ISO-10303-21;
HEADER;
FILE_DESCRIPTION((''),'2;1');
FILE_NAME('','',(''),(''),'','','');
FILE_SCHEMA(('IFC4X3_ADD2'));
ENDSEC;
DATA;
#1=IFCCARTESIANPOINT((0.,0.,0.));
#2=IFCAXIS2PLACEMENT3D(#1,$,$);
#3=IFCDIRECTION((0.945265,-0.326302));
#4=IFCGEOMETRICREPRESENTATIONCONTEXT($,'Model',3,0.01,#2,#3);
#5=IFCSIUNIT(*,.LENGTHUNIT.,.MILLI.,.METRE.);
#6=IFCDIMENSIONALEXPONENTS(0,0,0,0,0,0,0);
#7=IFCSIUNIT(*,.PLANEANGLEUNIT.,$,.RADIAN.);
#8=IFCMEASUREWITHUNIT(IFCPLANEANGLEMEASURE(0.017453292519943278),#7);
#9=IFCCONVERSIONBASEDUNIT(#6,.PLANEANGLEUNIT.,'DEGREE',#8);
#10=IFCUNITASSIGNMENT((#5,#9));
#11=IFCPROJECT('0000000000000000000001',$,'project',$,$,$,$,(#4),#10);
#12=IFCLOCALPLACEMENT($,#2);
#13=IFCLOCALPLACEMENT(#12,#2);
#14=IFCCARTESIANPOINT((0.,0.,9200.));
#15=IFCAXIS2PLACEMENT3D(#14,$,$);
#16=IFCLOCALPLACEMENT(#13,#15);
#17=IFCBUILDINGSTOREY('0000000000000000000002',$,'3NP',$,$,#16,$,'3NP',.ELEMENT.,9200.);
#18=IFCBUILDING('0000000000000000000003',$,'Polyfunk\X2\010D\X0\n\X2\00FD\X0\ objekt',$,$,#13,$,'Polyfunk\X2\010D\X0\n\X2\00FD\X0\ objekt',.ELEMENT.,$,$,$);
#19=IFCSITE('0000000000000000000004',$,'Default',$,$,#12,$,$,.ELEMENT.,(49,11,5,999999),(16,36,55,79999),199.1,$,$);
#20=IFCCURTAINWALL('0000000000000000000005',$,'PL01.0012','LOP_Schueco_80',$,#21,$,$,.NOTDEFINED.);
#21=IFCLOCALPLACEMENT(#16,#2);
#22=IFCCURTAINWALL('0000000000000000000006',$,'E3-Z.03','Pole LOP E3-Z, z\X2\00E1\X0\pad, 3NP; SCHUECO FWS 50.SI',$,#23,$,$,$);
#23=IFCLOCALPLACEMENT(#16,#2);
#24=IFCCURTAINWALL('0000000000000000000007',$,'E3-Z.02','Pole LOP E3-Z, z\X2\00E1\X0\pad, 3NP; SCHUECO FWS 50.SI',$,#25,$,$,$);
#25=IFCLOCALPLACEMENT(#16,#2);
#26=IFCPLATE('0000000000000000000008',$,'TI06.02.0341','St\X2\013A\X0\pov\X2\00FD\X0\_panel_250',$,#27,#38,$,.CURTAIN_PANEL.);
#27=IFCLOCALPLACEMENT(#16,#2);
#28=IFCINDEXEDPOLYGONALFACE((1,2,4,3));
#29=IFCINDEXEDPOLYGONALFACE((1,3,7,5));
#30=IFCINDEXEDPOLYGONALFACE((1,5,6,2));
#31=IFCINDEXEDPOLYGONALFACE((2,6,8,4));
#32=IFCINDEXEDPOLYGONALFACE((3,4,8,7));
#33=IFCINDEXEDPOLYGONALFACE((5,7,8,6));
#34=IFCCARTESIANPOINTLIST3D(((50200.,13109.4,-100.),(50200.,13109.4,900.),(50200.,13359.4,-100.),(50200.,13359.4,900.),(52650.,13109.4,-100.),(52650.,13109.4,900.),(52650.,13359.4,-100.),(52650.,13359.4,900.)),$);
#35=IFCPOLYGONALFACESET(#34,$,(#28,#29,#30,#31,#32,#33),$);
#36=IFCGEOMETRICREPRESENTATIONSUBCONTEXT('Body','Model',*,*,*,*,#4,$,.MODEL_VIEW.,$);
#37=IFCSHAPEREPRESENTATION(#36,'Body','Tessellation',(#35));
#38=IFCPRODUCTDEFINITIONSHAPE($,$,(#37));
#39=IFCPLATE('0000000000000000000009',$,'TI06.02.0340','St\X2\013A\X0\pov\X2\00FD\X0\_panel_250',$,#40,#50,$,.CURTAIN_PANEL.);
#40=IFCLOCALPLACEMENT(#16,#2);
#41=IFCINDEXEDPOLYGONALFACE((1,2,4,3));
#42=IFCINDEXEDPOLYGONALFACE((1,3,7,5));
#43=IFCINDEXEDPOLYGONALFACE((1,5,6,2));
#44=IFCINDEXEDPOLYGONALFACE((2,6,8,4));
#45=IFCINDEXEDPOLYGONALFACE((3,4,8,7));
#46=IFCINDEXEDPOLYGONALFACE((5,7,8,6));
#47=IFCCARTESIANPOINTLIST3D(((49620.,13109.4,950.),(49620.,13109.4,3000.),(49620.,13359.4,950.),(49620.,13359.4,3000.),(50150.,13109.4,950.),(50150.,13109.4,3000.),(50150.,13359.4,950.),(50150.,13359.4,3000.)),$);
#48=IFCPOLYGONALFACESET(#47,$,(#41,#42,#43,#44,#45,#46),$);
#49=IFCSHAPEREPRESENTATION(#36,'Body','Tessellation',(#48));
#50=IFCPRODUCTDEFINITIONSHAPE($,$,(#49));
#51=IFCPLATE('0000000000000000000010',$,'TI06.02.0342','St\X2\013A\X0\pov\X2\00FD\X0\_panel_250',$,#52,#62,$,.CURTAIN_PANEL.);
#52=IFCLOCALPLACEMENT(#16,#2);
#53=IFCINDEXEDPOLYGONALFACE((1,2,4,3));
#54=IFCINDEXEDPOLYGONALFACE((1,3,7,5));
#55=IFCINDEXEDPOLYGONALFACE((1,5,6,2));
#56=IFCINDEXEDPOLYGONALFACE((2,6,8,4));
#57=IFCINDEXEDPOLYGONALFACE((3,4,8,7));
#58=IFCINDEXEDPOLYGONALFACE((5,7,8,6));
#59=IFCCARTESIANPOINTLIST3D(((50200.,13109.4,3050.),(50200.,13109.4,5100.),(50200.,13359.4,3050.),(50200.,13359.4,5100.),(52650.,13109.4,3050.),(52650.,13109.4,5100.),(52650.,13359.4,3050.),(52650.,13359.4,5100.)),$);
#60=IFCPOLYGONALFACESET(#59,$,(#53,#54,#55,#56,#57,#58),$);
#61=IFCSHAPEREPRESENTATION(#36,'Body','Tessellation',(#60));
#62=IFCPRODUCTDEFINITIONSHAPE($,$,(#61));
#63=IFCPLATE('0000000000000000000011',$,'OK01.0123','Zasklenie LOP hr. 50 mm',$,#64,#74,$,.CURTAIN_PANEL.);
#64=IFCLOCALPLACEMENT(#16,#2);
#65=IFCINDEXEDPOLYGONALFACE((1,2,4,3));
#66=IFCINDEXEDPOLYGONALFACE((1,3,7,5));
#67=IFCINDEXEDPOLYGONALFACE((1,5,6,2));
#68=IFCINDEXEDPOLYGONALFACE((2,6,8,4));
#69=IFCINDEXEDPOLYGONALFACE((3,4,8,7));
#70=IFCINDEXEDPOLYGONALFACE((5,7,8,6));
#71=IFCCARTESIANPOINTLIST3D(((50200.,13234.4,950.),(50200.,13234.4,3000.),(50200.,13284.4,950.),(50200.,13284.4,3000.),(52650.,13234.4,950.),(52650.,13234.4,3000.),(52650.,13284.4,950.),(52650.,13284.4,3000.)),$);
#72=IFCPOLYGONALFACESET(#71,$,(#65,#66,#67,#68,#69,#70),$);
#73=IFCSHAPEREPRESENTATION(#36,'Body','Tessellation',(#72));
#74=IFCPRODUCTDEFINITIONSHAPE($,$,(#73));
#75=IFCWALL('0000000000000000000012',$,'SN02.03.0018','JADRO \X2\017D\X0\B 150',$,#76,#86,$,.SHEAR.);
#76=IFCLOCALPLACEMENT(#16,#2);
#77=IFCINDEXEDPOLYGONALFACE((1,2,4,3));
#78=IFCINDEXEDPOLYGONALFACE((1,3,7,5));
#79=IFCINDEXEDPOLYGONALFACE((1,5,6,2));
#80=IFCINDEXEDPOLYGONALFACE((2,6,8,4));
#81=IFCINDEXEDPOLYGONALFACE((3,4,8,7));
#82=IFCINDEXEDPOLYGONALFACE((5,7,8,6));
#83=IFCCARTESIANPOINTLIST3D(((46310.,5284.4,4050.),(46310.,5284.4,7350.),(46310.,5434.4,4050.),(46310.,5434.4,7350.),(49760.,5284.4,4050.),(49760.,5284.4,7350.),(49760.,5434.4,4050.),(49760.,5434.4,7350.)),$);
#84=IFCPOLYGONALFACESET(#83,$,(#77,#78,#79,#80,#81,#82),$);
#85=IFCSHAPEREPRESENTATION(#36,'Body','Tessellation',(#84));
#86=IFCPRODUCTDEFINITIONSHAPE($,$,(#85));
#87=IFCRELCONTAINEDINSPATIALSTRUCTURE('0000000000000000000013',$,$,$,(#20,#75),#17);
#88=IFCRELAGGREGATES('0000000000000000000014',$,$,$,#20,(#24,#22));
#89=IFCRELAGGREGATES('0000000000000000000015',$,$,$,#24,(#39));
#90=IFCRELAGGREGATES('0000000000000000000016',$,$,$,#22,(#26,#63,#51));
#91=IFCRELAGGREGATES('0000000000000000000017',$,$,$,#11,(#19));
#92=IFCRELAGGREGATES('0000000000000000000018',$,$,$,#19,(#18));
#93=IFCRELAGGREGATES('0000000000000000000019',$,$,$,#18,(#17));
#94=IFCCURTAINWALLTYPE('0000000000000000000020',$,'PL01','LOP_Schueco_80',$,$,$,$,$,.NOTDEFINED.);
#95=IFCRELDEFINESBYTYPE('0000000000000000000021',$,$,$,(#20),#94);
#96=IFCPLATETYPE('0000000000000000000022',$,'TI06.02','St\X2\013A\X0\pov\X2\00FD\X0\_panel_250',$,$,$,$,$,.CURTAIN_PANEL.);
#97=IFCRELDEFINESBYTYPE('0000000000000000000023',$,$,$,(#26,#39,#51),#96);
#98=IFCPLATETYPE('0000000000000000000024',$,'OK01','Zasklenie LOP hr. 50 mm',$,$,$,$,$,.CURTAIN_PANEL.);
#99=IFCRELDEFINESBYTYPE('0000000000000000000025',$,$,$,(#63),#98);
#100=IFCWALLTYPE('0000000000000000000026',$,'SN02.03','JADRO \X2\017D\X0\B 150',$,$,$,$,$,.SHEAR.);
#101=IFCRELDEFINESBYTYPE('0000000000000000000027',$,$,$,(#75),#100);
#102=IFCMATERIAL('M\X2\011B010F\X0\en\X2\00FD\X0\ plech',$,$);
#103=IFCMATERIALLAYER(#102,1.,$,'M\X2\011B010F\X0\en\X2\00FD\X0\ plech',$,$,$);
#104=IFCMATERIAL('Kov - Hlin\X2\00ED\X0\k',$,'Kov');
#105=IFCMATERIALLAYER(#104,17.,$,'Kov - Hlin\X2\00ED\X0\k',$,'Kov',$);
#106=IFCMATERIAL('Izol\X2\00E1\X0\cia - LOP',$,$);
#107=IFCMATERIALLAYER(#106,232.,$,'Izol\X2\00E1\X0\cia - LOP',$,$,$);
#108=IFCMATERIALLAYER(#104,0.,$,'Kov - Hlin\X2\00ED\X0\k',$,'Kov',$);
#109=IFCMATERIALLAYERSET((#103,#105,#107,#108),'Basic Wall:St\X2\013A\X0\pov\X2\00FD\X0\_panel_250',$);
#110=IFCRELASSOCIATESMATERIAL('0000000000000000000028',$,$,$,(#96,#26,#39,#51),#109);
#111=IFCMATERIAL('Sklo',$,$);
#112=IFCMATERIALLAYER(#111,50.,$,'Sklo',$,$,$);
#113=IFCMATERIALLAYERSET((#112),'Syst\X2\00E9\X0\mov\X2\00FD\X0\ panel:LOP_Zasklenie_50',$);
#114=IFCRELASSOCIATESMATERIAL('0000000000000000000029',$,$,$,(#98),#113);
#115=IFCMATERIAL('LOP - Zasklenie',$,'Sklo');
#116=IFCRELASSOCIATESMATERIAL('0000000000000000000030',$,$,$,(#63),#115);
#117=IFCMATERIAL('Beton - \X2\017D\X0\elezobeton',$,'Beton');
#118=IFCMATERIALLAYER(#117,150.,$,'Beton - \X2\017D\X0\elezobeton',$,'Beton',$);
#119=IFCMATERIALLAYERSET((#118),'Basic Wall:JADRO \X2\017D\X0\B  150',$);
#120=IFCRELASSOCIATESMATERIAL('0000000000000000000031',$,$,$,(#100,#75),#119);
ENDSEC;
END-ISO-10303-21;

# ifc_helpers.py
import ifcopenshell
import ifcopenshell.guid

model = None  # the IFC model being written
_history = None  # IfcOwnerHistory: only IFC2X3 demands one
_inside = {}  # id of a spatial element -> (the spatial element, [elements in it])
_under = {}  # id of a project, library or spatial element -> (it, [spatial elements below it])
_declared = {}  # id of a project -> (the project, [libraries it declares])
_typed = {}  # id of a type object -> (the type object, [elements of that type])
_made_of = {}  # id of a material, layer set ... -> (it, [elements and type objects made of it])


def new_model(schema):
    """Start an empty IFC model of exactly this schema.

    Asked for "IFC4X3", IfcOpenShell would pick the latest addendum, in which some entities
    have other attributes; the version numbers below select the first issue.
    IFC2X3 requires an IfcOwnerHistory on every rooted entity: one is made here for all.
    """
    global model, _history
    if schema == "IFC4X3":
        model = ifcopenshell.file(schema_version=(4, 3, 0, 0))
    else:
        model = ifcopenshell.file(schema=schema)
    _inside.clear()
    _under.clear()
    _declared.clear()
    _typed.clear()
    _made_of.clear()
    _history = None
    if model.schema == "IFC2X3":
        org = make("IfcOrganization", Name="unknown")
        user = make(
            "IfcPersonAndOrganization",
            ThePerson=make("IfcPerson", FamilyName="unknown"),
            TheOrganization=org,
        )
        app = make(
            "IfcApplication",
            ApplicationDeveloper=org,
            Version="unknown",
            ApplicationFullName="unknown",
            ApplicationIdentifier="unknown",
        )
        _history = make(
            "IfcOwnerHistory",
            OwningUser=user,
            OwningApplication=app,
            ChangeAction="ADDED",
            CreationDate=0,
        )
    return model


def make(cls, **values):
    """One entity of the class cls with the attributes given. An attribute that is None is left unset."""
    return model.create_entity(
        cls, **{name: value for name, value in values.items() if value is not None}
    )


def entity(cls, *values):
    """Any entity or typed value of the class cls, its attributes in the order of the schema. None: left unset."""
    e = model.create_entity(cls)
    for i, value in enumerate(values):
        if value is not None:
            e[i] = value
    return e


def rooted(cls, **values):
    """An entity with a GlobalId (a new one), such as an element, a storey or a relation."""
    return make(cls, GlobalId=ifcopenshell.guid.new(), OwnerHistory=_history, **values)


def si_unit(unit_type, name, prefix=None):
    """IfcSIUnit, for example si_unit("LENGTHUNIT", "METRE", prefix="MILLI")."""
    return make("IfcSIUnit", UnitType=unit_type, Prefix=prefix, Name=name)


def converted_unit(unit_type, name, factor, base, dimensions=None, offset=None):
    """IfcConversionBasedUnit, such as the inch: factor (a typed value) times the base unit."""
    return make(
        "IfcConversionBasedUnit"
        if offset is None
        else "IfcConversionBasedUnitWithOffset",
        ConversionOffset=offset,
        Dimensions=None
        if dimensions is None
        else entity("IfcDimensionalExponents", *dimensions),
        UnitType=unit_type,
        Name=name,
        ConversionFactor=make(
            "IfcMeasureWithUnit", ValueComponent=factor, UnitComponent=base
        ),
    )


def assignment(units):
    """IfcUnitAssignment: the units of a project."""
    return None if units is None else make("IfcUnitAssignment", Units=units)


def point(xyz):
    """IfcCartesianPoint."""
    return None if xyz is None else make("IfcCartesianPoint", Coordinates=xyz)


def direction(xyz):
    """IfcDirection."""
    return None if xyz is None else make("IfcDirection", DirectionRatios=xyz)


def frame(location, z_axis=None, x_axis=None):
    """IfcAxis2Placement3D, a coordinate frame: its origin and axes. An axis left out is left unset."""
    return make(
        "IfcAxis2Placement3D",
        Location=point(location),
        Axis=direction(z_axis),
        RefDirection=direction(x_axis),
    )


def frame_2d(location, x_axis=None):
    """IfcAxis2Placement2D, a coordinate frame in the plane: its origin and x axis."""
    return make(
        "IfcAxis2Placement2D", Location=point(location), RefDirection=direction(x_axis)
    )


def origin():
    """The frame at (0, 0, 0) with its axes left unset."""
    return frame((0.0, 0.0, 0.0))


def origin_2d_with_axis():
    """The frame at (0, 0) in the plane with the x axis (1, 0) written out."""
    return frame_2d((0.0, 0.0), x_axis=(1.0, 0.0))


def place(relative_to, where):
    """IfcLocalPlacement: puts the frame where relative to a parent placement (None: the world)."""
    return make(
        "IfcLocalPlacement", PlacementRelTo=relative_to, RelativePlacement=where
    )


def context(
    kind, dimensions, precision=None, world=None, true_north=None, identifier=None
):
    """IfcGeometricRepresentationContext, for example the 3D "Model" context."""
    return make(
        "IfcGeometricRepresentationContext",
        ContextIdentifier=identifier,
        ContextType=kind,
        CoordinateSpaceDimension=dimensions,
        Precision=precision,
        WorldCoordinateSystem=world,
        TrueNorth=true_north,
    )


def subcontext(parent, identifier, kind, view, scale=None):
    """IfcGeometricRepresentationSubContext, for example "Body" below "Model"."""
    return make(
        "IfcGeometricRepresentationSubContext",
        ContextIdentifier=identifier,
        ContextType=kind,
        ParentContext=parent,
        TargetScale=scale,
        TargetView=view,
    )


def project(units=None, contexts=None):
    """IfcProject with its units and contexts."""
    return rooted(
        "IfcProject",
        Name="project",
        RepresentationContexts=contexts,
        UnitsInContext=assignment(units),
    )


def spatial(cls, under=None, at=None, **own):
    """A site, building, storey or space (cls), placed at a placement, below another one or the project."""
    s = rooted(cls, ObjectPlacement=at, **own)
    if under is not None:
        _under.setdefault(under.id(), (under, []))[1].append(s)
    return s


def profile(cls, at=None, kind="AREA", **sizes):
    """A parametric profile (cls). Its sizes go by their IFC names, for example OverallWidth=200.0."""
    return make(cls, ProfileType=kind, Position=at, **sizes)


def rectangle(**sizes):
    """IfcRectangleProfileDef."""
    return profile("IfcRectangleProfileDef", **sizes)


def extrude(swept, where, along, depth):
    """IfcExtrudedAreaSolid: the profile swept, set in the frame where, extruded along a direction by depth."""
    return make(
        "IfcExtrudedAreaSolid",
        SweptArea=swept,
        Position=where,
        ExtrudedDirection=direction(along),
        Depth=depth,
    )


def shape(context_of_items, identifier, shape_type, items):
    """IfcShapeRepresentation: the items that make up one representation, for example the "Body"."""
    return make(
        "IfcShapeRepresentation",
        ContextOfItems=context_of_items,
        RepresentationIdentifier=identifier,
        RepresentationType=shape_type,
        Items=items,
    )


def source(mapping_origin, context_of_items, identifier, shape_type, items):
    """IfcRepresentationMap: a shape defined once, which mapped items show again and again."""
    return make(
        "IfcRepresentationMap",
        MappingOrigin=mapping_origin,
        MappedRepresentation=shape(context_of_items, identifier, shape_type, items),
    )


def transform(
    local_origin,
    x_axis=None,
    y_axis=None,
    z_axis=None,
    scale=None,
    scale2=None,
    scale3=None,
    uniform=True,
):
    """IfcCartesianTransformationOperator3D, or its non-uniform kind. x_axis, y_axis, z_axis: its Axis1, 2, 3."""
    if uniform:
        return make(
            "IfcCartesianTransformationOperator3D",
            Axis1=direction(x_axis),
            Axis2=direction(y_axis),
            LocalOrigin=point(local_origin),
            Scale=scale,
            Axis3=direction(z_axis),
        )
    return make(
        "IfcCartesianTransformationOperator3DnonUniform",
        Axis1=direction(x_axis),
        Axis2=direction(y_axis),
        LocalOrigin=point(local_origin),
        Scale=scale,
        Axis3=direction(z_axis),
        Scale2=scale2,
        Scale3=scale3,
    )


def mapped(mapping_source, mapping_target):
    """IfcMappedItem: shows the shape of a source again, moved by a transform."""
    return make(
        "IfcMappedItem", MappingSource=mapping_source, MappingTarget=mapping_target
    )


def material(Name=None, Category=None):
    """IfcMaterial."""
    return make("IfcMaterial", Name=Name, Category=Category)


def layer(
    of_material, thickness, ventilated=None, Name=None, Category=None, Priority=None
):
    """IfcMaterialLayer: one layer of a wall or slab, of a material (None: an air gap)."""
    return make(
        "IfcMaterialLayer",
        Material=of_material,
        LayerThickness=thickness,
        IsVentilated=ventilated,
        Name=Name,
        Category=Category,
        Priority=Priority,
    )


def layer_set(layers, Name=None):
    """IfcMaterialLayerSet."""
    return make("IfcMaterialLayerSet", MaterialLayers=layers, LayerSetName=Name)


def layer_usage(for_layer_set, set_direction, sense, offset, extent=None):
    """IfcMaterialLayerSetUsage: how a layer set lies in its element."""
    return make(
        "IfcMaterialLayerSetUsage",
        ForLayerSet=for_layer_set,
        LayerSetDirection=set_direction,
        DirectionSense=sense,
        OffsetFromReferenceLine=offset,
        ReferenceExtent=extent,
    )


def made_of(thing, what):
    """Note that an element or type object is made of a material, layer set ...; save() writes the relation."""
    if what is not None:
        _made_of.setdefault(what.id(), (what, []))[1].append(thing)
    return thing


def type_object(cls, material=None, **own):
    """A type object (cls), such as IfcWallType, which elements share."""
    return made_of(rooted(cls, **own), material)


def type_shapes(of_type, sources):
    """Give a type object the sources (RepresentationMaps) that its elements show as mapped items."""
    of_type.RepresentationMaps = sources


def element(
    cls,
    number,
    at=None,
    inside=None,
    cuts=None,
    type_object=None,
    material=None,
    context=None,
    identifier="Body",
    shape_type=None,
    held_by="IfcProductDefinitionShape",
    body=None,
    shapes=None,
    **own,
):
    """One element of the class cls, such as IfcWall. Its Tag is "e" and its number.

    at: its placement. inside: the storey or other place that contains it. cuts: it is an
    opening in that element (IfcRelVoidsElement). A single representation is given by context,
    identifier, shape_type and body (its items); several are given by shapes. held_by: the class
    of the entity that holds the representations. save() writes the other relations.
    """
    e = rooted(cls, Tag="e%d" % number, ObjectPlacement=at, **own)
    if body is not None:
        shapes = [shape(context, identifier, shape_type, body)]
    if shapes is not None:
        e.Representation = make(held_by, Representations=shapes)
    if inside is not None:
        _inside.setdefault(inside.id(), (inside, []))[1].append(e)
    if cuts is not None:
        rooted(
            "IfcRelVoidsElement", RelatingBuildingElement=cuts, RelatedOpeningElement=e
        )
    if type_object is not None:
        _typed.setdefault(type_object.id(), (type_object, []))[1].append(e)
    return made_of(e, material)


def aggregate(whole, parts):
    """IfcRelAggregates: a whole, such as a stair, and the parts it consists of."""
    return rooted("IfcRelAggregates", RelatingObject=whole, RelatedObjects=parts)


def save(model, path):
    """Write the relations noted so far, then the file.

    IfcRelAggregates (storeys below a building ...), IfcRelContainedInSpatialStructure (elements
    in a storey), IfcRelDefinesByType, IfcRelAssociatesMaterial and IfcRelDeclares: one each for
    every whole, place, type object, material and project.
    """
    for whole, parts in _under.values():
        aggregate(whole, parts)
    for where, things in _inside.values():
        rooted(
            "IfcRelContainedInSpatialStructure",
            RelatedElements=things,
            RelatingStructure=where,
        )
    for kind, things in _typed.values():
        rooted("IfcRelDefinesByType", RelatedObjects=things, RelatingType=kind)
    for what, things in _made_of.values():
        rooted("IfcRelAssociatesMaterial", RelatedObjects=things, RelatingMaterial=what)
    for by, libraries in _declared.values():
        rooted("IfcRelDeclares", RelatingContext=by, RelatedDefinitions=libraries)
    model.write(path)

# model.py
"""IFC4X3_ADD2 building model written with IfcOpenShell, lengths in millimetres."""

from ifc_helpers import new_model, entity, si_unit, converted_unit, direction, frame, frame_2d, origin, origin_2d_with_axis, place, context, subcontext, project, spatial, rectangle, extrude, source, transform, mapped, material, layer, layer_set, layer_usage, type_object, type_shapes, element, aggregate, save


model = new_model("IFC4X3_ADD2")

# Units and contexts
model_context = context("Model", 3, precision=0.01, world=origin(), true_north=direction((0.945265, -0.326302)))
body_context = subcontext(model_context, "Body", "Model", "MODEL_VIEW")
ifc_project = project(units=[si_unit("LENGTHUNIT", "METRE", prefix="MILLI"), converted_unit("PLANEANGLEUNIT", "DEGREE", entity("IfcPlaneAngleMeasure", 0.017453292519943278), si_unit("PLANEANGLEUNIT", "RADIAN"), dimensions=[0, 0, 0, 0, 0, 0, 0])], contexts=[model_context])

# Site, building, storey
site_placement = place(None, origin())
site = spatial("IfcSite", under=ifc_project, at=site_placement, Name="Default", CompositionType="ELEMENT", RefLatitude=(49, 11, 5, 999999), RefLongitude=(16, 36, 55, 79999), RefElevation=199.1)
building_placement = place(site_placement, origin())
building = spatial("IfcBuilding", under=site, at=building_placement, Name="Polyfunkčný objekt", LongName="Polyfunkčný objekt", CompositionType="ELEMENT")
storey_placement = place(building_placement, frame((0.0, 0.0, 9200.0)))
storey = spatial("IfcBuildingStorey", under=building, at=storey_placement, Name="3NP", LongName="3NP", CompositionType="ELEMENT", Elevation=9200.0)

# Curtain walls, plates
curtain_wall_type = type_object("IfcCurtainWallType", Name="PL01", Description="LOP_Schueco_80", PredefinedType="NOTDEFINED")
curtain_wall_1_placement = place(storey_placement, frame((0.0, 0.0, -9200.0)))
curtain_wall_1 = element("IfcCurtainWall", 1, at=curtain_wall_1_placement, inside=storey, type_object=curtain_wall_type, Name="PL01.0012", Description="LOP_Schueco_80", PredefinedType="NOTDEFINED")
curtain_wall_2 = element("IfcCurtainWall", 2, Name="E3-Z.03", Description="Pole LOP E3-Z, západ, 3NP; SCHUECO FWS 50.SI")
curtain_wall_3 = element("IfcCurtainWall", 3, Name="E3-Z.02", Description="Pole LOP E3-Z, západ, 3NP; SCHUECO FWS 50.SI")
aggregate(curtain_wall_1, [curtain_wall_3, curtain_wall_2])
ifc_material_1 = material(Name="Měďený plech")
ifc_layer_1 = layer(ifc_material_1, 1.0, Name="Měďený plech")
ifc_material_2 = material(Name="Kov - Hliník", Category="Kov")
ifc_layer_2 = layer(ifc_material_2, 17.0, Name="Kov - Hliník", Category="Kov")
ifc_material_3 = material(Name="Izolácia - LOP")
ifc_layer_3 = layer(ifc_material_3, 232.0, Name="Izolácia - LOP")
ifc_layer_4 = layer(ifc_material_2, 0.0, Name="Kov - Hliník", Category="Kov")
ifc_layer_set_1 = layer_set([ifc_layer_1, ifc_layer_2, ifc_layer_3, ifc_layer_4], Name="Basic Wall:Stĺpový_panel_250")
ifc_layer_usage_1 = layer_usage(ifc_layer_set_1, "AXIS2", "NEGATIVE", 125.0)
plate_type_1 = type_object("IfcPlateType", Name="TI06.02", Description="Stĺpový_panel_250", PredefinedType="CURTAIN_PANEL", material=ifc_layer_set_1)
plate_1_placement = place(storey_placement, frame((50200.0, 13234.4, -100.0)))
plate_1 = element("IfcPlate", 4, at=plate_1_placement, type_object=plate_type_1, material=ifc_layer_usage_1, Name="TI06.02.0341", Description="Stĺpový_panel_250", PredefinedType="CURTAIN_PANEL", context=body_context, shape_type="SweptSolid", body=[
    extrude(rectangle(XDim=250.0, YDim=2450.0, at=origin_2d_with_axis()), frame((1225.0, 0.0, 0.0), z_axis=(0.0, 0.0, 1.0), x_axis=(0.0, 1.0, 0.0)), (0.0, 0.0, 1.0), 1000.0),
])
ifc_layer_usage_2 = layer_usage(ifc_layer_set_1, "AXIS2", "NEGATIVE", 125.0)
plate_2_placement = place(storey_placement, frame((49620.0, 13234.4, 950.0)))
plate_2 = element("IfcPlate", 5, at=plate_2_placement, type_object=plate_type_1, material=ifc_layer_usage_2, Name="TI06.02.0340", Description="Stĺpový_panel_250", PredefinedType="CURTAIN_PANEL", context=body_context, shape_type="SweptSolid", body=[
    extrude(rectangle(XDim=250.0, YDim=530.0, at=frame_2d((0.0, 0.0), x_axis=(1.0, 0.0))), frame((265.0, 0.0, 0.0), z_axis=(0.0, 0.0, 1.0), x_axis=(0.0, 1.0, 0.0)), (0.0, 0.0, 1.0), 2050.0),
])
aggregate(curtain_wall_3, [plate_2])
ifc_layer_usage_3 = layer_usage(ifc_layer_set_1, "AXIS2", "NEGATIVE", 125.0)
plate_3_placement = place(storey_placement, frame((50200.0, 13234.4, 3050.0)))
plate_3 = element("IfcPlate", 6, at=plate_3_placement, type_object=plate_type_1, material=ifc_layer_usage_3, Name="TI06.02.0342", Description="Stĺpový_panel_250", PredefinedType="CURTAIN_PANEL", context=body_context, shape_type="SweptSolid", body=[
    extrude(rectangle(XDim=250.0, YDim=2450.0, at=origin_2d_with_axis()), frame((1225.0, 0.0, 0.0), z_axis=(0.0, 0.0, 1.0), x_axis=(0.0, 1.0, 0.0)), (0.0, 0.0, 1.0), 2050.0),
])
ifc_material_4 = material(Name="LOP - Zasklenie", Category="Sklo")
ifc_material_5 = material(Name="Sklo")
ifc_layer_5 = layer(ifc_material_5, 50.0, Name="Sklo")
ifc_layer_set_2 = layer_set([ifc_layer_5], Name="Systémový panel:LOP_Zasklenie_50")
plate_type_2 = type_object("IfcPlateType", Name="OK01", Description="Zasklenie LOP hr. 50 mm", PredefinedType="CURTAIN_PANEL", material=ifc_layer_set_2)
shared_shape_1 = source(origin(), body_context, "Body", "SweptSolid", [
    extrude(rectangle(XDim=50.0, YDim=2450.0, at=origin_2d_with_axis()), frame((0.0, 25.0, 0.0), z_axis=(0.0, 0.0, 1.0), x_axis=(0.0, 1.0, 0.0)), (0.0, 0.0, 1.0), 2050.0),
])
type_shapes(plate_type_2, [shared_shape_1])
plate_4_placement = place(curtain_wall_1_placement, frame((51425.0, 13234.4, 10150.0)))
plate_4 = element("IfcPlate", 7, at=plate_4_placement, type_object=plate_type_2, material=ifc_material_4, Name="OK01.0123", Description="Zasklenie LOP hr. 50 mm", PredefinedType="CURTAIN_PANEL", context=body_context, shape_type="MappedRepresentation", body=[
    mapped(shared_shape_1, transform((0.0, 0.0, 0.0), scale=1.0)),
])
aggregate(curtain_wall_2, [plate_1, plate_4, plate_3])

# Wall
ifc_material_6 = material(Name="Beton - Železobeton", Category="Beton")
ifc_layer_6 = layer(ifc_material_6, 150.0, Name="Beton - Železobeton", Category="Beton")
ifc_layer_set_3 = layer_set([ifc_layer_6], Name="Basic Wall:JADRO ŽB  150")
wall_type = type_object("IfcWallType", Name="SN02.03", Description="JADRO ŽB 150", PredefinedType="SHEAR", material=ifc_layer_set_3)
wall_placement = place(storey_placement, frame((46310.0, 5359.4, 4050.0)))
element("IfcWall", 8, at=wall_placement, inside=storey, type_object=wall_type, material=ifc_layer_set_3, Name="SN02.03.0018", Description="JADRO ŽB 150", PredefinedType="SHEAR", context=body_context, shape_type="SweptSolid", body=[
    extrude(rectangle(XDim=3450.0, YDim=150.0, at=frame_2d((1725.0, 0.0), x_axis=(-1.0, 0.0))), origin(), (0.0, 0.0, 1.0), 3300.0),
])

save(model, "model.ifc")
